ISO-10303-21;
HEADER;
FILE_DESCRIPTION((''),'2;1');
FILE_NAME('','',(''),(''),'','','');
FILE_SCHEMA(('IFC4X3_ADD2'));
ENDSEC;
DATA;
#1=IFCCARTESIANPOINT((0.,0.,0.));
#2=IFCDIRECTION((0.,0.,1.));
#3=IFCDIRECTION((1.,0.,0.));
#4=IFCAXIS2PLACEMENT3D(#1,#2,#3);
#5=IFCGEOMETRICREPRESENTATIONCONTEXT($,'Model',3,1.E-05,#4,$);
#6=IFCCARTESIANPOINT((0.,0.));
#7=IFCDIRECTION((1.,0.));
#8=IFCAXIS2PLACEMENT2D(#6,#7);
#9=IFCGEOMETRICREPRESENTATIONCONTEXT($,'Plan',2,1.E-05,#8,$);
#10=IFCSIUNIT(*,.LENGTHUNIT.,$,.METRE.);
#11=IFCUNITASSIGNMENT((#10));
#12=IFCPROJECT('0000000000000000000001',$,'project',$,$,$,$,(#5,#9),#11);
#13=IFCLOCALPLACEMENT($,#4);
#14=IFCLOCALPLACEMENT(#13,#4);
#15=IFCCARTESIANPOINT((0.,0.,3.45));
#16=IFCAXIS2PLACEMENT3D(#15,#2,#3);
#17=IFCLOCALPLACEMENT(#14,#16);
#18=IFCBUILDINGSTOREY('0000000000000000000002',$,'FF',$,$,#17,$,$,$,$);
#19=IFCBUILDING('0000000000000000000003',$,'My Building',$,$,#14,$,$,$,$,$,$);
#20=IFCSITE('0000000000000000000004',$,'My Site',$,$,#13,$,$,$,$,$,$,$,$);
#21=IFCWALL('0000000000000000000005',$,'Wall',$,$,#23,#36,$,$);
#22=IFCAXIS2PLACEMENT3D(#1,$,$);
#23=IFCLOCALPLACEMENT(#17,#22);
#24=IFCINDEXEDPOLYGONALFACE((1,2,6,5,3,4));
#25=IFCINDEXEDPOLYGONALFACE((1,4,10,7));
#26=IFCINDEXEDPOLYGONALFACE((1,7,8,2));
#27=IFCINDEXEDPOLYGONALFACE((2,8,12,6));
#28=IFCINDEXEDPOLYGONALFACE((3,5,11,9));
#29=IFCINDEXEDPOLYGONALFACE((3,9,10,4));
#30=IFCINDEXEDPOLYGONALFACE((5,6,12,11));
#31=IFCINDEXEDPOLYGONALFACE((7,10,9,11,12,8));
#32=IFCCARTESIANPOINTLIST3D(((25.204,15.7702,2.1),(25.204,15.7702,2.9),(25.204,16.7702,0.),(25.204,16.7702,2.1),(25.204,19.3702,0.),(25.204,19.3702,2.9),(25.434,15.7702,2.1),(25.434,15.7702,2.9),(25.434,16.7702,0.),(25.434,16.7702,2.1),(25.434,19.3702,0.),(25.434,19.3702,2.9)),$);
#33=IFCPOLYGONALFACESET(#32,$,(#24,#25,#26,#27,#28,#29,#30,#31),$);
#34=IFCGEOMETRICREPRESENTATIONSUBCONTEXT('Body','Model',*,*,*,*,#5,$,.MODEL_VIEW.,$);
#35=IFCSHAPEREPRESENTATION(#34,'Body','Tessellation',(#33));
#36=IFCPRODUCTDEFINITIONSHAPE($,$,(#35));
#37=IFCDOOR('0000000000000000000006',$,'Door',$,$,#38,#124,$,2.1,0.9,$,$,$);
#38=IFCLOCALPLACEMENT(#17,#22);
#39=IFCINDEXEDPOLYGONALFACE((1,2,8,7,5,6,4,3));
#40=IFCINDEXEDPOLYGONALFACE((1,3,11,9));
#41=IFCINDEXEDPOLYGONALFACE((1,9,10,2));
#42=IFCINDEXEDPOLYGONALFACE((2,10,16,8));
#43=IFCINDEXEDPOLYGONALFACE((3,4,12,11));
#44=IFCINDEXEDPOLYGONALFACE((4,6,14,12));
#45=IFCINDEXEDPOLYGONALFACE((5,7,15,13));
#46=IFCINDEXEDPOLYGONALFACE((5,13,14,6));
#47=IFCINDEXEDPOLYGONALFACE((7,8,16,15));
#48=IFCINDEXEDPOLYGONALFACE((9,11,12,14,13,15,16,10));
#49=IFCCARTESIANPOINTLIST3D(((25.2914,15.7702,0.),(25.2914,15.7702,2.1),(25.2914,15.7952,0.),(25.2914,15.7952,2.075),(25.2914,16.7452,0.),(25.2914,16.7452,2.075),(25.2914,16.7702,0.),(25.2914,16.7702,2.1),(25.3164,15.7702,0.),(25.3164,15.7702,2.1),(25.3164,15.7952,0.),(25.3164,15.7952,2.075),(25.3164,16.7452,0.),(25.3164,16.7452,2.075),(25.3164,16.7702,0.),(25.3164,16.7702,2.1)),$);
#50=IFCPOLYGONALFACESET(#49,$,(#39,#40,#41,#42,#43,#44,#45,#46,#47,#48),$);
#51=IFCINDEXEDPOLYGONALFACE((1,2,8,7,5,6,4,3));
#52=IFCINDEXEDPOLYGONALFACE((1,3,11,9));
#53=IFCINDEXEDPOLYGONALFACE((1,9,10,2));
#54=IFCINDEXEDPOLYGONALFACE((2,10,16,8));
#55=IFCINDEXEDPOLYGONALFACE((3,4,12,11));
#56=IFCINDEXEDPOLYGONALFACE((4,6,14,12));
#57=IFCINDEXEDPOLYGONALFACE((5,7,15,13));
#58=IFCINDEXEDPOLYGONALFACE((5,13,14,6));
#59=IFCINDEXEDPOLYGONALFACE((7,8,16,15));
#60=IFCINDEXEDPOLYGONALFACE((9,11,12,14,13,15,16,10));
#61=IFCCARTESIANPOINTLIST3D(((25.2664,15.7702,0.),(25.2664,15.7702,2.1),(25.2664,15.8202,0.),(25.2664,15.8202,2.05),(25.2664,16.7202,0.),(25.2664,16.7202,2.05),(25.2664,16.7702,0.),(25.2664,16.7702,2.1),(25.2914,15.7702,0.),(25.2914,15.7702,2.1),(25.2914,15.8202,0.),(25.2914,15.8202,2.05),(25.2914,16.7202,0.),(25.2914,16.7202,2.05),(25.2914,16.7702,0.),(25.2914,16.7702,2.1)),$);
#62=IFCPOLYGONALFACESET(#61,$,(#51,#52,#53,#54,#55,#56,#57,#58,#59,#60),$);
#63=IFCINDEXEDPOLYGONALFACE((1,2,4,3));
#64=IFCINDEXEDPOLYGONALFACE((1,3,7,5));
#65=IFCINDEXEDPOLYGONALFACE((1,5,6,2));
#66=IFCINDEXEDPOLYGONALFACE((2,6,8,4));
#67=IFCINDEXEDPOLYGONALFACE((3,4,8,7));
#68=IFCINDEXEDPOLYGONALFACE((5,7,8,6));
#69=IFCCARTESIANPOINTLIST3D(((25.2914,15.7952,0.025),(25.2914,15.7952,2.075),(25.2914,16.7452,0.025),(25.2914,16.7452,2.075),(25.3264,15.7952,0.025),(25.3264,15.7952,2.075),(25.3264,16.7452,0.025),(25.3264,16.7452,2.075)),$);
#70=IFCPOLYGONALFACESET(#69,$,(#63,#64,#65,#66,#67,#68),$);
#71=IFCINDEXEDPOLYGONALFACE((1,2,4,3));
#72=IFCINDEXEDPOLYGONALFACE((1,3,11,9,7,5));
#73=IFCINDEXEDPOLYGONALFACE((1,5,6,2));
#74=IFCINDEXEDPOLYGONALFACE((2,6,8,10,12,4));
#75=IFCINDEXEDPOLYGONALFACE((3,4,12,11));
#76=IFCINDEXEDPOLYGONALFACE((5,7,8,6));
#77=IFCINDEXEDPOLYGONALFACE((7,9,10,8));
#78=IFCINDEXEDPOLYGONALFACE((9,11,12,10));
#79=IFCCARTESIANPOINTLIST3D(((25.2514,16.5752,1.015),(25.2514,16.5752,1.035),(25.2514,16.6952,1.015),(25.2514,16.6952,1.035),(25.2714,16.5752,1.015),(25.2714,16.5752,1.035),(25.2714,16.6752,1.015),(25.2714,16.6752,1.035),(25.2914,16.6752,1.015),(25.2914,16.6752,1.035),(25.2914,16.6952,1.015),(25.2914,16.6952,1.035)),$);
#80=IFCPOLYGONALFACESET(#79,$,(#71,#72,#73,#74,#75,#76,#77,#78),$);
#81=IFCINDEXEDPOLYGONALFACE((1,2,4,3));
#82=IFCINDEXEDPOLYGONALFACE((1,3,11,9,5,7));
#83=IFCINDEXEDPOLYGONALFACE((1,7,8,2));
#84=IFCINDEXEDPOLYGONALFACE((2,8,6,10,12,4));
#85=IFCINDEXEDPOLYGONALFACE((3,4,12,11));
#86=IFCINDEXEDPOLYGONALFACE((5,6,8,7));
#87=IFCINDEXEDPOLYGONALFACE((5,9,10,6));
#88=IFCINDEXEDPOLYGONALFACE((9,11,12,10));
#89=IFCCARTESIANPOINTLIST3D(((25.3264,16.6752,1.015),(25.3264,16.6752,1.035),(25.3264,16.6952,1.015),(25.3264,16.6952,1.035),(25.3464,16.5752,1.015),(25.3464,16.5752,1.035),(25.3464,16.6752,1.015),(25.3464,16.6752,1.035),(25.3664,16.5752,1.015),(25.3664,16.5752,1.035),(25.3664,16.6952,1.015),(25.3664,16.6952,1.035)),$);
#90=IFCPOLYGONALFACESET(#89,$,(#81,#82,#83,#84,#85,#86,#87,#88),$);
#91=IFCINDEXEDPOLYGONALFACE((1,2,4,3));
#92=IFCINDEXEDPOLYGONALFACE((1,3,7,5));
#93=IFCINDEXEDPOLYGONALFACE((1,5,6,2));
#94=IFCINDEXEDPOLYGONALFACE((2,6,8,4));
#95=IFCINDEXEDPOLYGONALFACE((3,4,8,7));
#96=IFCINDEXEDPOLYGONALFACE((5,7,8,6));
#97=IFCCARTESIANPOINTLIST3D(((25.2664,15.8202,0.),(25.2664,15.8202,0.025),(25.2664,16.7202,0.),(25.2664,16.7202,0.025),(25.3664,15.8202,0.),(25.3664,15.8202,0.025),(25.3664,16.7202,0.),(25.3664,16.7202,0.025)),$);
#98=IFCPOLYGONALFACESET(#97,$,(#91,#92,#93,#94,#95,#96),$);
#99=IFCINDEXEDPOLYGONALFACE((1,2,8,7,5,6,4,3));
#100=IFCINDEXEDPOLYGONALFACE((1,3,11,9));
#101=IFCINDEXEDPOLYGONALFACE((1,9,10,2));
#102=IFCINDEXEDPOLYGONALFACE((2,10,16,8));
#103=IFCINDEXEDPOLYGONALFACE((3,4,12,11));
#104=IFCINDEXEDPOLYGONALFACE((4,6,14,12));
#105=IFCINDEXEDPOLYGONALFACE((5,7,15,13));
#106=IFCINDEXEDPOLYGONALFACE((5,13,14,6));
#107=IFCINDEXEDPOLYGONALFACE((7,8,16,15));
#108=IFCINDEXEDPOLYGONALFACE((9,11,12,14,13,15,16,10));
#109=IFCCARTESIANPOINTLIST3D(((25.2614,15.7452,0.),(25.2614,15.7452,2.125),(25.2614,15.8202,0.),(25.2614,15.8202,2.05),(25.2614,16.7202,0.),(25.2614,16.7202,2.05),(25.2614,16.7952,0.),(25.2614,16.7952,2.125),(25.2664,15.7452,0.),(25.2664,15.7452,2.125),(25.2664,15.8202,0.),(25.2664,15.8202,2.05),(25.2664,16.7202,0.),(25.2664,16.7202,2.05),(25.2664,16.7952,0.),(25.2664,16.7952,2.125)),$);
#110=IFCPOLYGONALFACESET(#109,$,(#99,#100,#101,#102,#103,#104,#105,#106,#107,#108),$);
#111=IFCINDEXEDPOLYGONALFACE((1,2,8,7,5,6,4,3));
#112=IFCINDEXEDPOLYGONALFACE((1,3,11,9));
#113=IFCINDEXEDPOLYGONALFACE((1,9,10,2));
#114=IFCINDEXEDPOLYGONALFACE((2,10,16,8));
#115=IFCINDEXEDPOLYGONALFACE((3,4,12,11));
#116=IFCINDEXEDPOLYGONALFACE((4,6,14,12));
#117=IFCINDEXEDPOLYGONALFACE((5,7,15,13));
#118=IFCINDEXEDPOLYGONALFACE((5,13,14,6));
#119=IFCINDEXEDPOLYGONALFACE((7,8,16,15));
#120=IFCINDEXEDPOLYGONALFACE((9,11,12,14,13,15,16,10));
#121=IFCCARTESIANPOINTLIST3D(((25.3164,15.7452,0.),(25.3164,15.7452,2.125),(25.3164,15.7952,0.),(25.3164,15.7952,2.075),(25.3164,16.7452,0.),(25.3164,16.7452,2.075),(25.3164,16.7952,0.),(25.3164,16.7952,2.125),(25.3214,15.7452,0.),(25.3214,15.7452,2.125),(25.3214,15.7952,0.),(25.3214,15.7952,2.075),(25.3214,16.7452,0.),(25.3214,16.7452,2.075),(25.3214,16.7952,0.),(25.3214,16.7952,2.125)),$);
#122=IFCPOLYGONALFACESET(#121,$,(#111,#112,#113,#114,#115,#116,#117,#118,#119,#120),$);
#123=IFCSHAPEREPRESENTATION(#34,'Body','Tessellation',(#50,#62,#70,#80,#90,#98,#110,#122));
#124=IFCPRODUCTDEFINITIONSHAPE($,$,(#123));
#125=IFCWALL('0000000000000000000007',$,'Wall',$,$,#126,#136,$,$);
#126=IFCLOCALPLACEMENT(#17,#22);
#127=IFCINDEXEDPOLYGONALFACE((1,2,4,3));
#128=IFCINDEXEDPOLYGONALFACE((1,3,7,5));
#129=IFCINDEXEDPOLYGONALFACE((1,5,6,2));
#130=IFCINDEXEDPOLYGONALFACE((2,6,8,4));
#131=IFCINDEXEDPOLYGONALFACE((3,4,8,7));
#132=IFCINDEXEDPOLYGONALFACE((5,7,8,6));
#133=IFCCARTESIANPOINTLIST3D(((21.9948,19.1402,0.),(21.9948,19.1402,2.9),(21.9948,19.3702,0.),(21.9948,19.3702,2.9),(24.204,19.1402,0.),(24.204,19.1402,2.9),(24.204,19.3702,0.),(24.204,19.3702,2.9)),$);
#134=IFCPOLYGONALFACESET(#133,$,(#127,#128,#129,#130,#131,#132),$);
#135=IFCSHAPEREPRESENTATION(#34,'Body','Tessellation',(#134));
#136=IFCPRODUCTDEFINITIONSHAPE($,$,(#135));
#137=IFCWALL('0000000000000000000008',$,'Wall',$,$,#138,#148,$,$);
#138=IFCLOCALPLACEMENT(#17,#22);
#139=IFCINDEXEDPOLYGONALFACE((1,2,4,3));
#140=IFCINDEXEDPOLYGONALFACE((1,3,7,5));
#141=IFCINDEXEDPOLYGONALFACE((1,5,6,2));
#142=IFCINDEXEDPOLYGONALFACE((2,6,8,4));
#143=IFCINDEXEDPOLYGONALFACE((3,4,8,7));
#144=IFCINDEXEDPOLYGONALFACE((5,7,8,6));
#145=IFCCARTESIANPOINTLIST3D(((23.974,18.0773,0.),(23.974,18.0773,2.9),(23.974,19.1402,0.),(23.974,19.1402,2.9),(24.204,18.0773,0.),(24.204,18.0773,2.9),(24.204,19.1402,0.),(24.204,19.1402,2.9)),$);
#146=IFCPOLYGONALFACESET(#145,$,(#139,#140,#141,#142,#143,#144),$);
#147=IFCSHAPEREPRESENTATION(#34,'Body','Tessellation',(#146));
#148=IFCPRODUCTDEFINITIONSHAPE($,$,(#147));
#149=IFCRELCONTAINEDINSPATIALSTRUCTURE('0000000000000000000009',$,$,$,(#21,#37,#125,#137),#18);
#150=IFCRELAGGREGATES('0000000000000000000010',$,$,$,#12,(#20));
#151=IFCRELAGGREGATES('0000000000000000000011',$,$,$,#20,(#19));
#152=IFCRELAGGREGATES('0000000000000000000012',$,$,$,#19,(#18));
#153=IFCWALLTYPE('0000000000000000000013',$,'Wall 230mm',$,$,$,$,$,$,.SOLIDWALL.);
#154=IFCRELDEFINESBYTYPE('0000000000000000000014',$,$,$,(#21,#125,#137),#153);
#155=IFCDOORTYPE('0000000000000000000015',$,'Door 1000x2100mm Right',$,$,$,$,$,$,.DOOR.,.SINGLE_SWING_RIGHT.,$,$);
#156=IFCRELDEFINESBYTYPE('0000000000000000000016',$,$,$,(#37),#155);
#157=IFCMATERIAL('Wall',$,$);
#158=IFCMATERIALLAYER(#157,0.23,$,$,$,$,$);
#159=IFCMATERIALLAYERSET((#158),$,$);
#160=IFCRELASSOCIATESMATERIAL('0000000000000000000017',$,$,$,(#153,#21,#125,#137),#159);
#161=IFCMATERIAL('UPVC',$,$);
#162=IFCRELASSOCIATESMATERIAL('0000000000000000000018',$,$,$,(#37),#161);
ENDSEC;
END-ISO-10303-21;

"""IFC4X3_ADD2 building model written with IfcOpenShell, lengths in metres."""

from ifc_helpers import new_model, entity, si_unit, frame, origin_with_axes, origin_2d_with_axis, place, context, subcontext, project, spatial, line, indexed_curve, outline, extrude, shape, source, transform, mapped, material, layer, layer_set, layer_usage, type_object, type_shapes, element, fill, save


model = new_model("IFC4X3_ADD2")

# Units and contexts
model_context = context("Model", 3, precision=1e-05, world=origin_with_axes())
plan_context = context("Plan", 2, precision=1e-05, world=origin_2d_with_axis())
body_context_1 = subcontext(model_context, "Body", "Model", "MODEL_VIEW")
body_context_2 = subcontext(plan_context, "Body", "Plan", "PLAN_VIEW")
ifc_project = project(units=[si_unit("LENGTHUNIT", "METRE")], contexts=[model_context, plan_context])

# Site, building, storey
site_placement = place(None, origin_with_axes())
site = spatial("IfcSite", under=ifc_project, at=site_placement, Name="My Site")
building_placement = place(site_placement, origin_with_axes())
building = spatial("IfcBuilding", under=site, at=building_placement, Name="My Building")
storey_placement = place(building_placement, frame((0.0, 0.0, 3.45), z_axis=(0.0, 0.0, 1.0), x_axis=(1.0, 0.0, 0.0)))
storey = spatial("IfcBuildingStorey", under=building, at=storey_placement, Name="FF")

# Shared definitions
ifc_material_1 = material(Name="Wall")
ifc_material_2 = material(Name="UPVC")

# Shared definitions
ifc_layer_1 = layer(ifc_material_1, 0.23)
ifc_layer_set_1 = layer_set([ifc_layer_1])
wall_type_1 = type_object("IfcWallType", Name="Wall 230mm", PredefinedType="SOLIDWALL", material=ifc_layer_set_1)

# Wall, opening, door
ifc_layer_usage_1 = layer_usage(ifc_layer_set_1, "AXIS2", "POSITIVE", 0.0)
wall_1_placement = place(storey_placement, frame((25.434, 15.7702, 0.0), z_axis=(0.0, 0.0, 1.0), x_axis=(0.000001, 1.0, 0.0)))
wall_1 = element("IfcWall", 1, at=wall_1_placement, inside=storey, type_object=wall_type_1, material=ifc_layer_usage_1, Name="Wall", context=body_context_1, shape_type="SweptSolid", body=[
    extrude(outline(indexed_curve([(0.0, 0.0), (0.0, 0.23), (3.6, 0.23), (3.6, 0.0), (0.0, 0.0)], self_intersect=False)), origin_with_axes(), (0.0, 0.0, 1.0), 2.9),
])
shared_shape_1 = source(origin_with_axes(), body_context_1, "Body", "SweptSolid", [
    extrude(outline(indexed_curve([(0.0, 0.0), (1.0, 0.0), (1.0, 2.1), (0.0, 2.1)], segments=[line(1, 2, 3, 4, 1)])), frame((0.0, -0.6, 0.0), z_axis=(0.0, -1.0, 0.0), x_axis=(1.0, 0.0, 0.0)), (0.0, 0.0, -1.0), 1.2),
])
opening_1_placement = place(wall_1_placement, frame((1.0, 0.1676, 0.0), z_axis=(0.0, 0.0, 1.0), x_axis=(-1.0, 0.0, 0.0)))
opening_1 = element("IfcOpeningElement", 2, at=opening_1_placement, cuts=wall_1, PredefinedType="OPENING", context=body_context_1, shape_type="MappedRepresentation", body=[
    mapped(shared_shape_1, transform((0.0, 0.0, 0.0), x_axis=(1.0, 0.0, 0.0), y_axis=(0.0, 1.0, 0.0), z_axis=(0.0, 0.0, 1.0), scale=1.0)),
])
door_type_1 = type_object("IfcDoorType", Name="Door 1000x2100mm Right", OperationType="SINGLE_SWING_RIGHT", PredefinedType="DOOR")
shared_shape_2 = source(origin_with_axes(), body_context_1, "Body", "SweptSolid", [
    extrude(outline(indexed_curve([(0.0, 0.0), (0.0, 2.1), (1.0, 2.1), (1.0, 0.0), (0.975, 0.0), (0.975, 2.075), (0.025, 2.075), (0.025, 0.0)], segments=[line(1, 2, 3, 4, 5, 6, 7, 8, 1)])), frame((0.0, 0.025, 0.0), z_axis=(0.0, -1.0, 0.0), x_axis=(1.0, 0.0, 0.0)), (0.0, 0.0, -1.0), 0.025),
    extrude(outline(indexed_curve([(0.0, 0.0), (0.0, 2.1), (1.0, 2.1), (1.0, 0.0), (0.95, 0.0), (0.95, 2.05), (0.05, 2.05), (0.05, 0.0)], segments=[line(1, 2, 3, 4, 5, 6, 7, 8, 1)])), frame((0.0, 0.0, 0.0), z_axis=(0.0, -1.0, 0.0), x_axis=(1.0, 0.0, 0.0)), (0.0, 0.0, -1.0), 0.025),
    extrude(outline(indexed_curve([(0.0, 0.0), (0.95, 0.0), (0.95, 0.035), (0.0, 0.035)], segments=[line(1, 2, 3, 4, 1)])), frame((0.025, 0.025, 0.025), z_axis=(0.0, 0.0, 1.0), x_axis=(1.0, 0.0, 0.0)), (0.0, 0.0, 1.0), 2.05),
    extrude(outline(indexed_curve([(0.0, 0.0), (0.0, -0.04), (0.12, -0.04), (0.12, -0.02), (0.02, -0.02), (0.02, 0.0)], segments=[line(1, 2, 3, 4, 5, 6, 1)])), frame((0.075, 0.025, 1.015), z_axis=(0.0, 0.0, 1.0), x_axis=(1.0, 0.0, 0.0)), (0.0, 0.0, 1.0), 0.02),
    extrude(outline(indexed_curve([(0.0, 0.0), (0.0, 0.04), (0.12, 0.04), (0.12, 0.02), (0.02, 0.02), (0.02, 0.0)], segments=[line(1, 2, 3, 4, 5, 6, 1)])), frame((0.075, 0.06, 1.015), z_axis=(0.0, 0.0, 1.0), x_axis=(1.0, 0.0, 0.0)), (0.0, 0.0, 1.0), 0.02),
    extrude(outline(indexed_curve([(0.0, 0.0), (0.9, 0.0), (0.9, 0.1), (0.0, 0.1)], segments=[line(1, 2, 3, 4, 1)])), frame((0.05, 0.0, 0.0), z_axis=(0.0, 0.0, 1.0), x_axis=(1.0, 0.0, 0.0)), (0.0, 0.0, 1.0), 0.025),
    extrude(outline(indexed_curve([(0.0, 0.0), (0.0, 2.125), (1.05, 2.125), (1.05, 0.0), (0.975, 0.0), (0.975, 2.05), (0.075, 2.05), (0.075, 0.0)], segments=[line(1, 2, 3, 4, 5, 6, 7, 8, 1)])), frame((-0.025, -0.005, 0.0), z_axis=(0.0, -1.0, 0.0), x_axis=(1.0, 0.0, 0.0)), (0.0, 0.0, -1.0), 0.005),
    extrude(outline(indexed_curve([(0.0, 0.0), (0.0, 2.125), (1.05, 2.125), (1.05, 0.0), (1.0, 0.0), (1.0, 2.075), (0.05, 2.075), (0.05, 0.0)], segments=[line(1, 2, 3, 4, 5, 6, 7, 8, 1)])), frame((-0.025, 0.05, 0.0), z_axis=(0.0, -1.0, 0.0), x_axis=(1.0, 0.0, 0.0)), (0.0, 0.0, -1.0), 0.005),
])
shared_shape_3 = source(origin_with_axes(), body_context_2, "Body", "Curve2D", [
    entity("IfcIndexedPolyCurve", entity("IfcCartesianPointList2D", [[0.0, 0.0], [0.0, 0.05], [0.025, 0.05], [0.025, 0.025], [0.05, 0.025], [0.05, 0.0]]), [entity("IfcLineIndex", [1, 2, 3, 4, 5, 6, 1])]),
    entity("IfcIndexedPolyCurve", entity("IfcCartesianPointList2D", [[1.0, 0.0], [1.0, 0.05], [0.975, 0.05], [0.975, 0.025], [0.95, 0.025], [0.95, 0.0]]), [entity("IfcLineIndex", [1, 2, 3, 4, 5, 6, 1])]),
    entity("IfcTrimmedCurve", entity("IfcEllipse", entity("IfcAxis2Placement2D", entity("IfcCartesianPoint", [0.94, 0.05]), entity("IfcDirection", [1.0, 0.0])), 0.915, 0.95), [entity("IfcCartesianPoint", [0.94, 1.0])], [entity("IfcCartesianPoint", [0.025, 0.05])], True, "CARTESIAN"),
    entity("IfcIndexedPolyCurve", entity("IfcCartesianPointList2D", [[0.975, 0.05], [0.94, 0.05], [0.94, 1.0], [0.975, 1.0]]), [entity("IfcLineIndex", [1, 2, 3, 4, 1])]),
])
type_shapes(door_type_1, [shared_shape_2, shared_shape_3])
door_1_placement = place(opening_1_placement, origin_with_axes())
door_1 = element("IfcDoor", 3, at=door_1_placement, inside=storey, type_object=door_type_1, material=ifc_material_2, Name="Door", OverallHeight=2.1, OverallWidth=0.9, shapes=[
    shape(body_context_1, "Body", "MappedRepresentation", [mapped(shared_shape_2, transform((0.0, 0.0, 0.0), x_axis=(1.0, 0.0, 0.0), y_axis=(0.0, 1.0, 0.0), z_axis=(0.0, 0.0, 1.0), scale=1.0))]),
    shape(body_context_2, "Body", "MappedRepresentation", [mapped(shared_shape_3, transform((0.0, 0.0, 0.0), x_axis=(1.0, 0.0, 0.0), y_axis=(0.0, 1.0, 0.0), z_axis=(0.0, 0.0, 1.0), scale=1.0))]),
])
fill(opening_1, door_1)

# Walls
ifc_layer_usage_2 = layer_usage(ifc_layer_set_1, "AXIS2", "POSITIVE", 0.0)
wall_2_placement = place(storey_placement, frame((24.204, 19.3702, 0.0), z_axis=(0.0, 0.0, 1.0), x_axis=(-1.0, 0.0, 0.0)))
element("IfcWall", 4, at=wall_2_placement, inside=storey, type_object=wall_type_1, material=ifc_layer_usage_2, Name="Wall", context=body_context_1, shape_type="SweptSolid", body=[
    extrude(outline(indexed_curve([(0.0, 0.0), (0.0, 0.23), (2.2092, 0.23), (2.2092, 0.0), (0.0, 0.0)], self_intersect=False)), origin_with_axes(), (0.0, 0.0, 1.0), 2.9),
])
ifc_layer_usage_3 = layer_usage(ifc_layer_set_1, "AXIS2", "POSITIVE", 0.0)
wall_3_placement = place(storey_placement, frame((24.204, 18.0773, 0.0), z_axis=(0.0, 0.0, 1.0), x_axis=(0.000001, 1.0, 0.0)))
element("IfcWall", 5, at=wall_3_placement, inside=storey, type_object=wall_type_1, material=ifc_layer_usage_3, Name="Wall", context=body_context_1, shape_type="SweptSolid", body=[
    extrude(outline(indexed_curve([(0.0, 0.0), (0.0, 0.23), (1.0629, 0.23), (1.0629, 0.0), (0.0, 0.0)], self_intersect=False)), origin_with_axes(), (0.0, 0.0, 1.0), 2.9),
])

save(model, "model.ifc")
